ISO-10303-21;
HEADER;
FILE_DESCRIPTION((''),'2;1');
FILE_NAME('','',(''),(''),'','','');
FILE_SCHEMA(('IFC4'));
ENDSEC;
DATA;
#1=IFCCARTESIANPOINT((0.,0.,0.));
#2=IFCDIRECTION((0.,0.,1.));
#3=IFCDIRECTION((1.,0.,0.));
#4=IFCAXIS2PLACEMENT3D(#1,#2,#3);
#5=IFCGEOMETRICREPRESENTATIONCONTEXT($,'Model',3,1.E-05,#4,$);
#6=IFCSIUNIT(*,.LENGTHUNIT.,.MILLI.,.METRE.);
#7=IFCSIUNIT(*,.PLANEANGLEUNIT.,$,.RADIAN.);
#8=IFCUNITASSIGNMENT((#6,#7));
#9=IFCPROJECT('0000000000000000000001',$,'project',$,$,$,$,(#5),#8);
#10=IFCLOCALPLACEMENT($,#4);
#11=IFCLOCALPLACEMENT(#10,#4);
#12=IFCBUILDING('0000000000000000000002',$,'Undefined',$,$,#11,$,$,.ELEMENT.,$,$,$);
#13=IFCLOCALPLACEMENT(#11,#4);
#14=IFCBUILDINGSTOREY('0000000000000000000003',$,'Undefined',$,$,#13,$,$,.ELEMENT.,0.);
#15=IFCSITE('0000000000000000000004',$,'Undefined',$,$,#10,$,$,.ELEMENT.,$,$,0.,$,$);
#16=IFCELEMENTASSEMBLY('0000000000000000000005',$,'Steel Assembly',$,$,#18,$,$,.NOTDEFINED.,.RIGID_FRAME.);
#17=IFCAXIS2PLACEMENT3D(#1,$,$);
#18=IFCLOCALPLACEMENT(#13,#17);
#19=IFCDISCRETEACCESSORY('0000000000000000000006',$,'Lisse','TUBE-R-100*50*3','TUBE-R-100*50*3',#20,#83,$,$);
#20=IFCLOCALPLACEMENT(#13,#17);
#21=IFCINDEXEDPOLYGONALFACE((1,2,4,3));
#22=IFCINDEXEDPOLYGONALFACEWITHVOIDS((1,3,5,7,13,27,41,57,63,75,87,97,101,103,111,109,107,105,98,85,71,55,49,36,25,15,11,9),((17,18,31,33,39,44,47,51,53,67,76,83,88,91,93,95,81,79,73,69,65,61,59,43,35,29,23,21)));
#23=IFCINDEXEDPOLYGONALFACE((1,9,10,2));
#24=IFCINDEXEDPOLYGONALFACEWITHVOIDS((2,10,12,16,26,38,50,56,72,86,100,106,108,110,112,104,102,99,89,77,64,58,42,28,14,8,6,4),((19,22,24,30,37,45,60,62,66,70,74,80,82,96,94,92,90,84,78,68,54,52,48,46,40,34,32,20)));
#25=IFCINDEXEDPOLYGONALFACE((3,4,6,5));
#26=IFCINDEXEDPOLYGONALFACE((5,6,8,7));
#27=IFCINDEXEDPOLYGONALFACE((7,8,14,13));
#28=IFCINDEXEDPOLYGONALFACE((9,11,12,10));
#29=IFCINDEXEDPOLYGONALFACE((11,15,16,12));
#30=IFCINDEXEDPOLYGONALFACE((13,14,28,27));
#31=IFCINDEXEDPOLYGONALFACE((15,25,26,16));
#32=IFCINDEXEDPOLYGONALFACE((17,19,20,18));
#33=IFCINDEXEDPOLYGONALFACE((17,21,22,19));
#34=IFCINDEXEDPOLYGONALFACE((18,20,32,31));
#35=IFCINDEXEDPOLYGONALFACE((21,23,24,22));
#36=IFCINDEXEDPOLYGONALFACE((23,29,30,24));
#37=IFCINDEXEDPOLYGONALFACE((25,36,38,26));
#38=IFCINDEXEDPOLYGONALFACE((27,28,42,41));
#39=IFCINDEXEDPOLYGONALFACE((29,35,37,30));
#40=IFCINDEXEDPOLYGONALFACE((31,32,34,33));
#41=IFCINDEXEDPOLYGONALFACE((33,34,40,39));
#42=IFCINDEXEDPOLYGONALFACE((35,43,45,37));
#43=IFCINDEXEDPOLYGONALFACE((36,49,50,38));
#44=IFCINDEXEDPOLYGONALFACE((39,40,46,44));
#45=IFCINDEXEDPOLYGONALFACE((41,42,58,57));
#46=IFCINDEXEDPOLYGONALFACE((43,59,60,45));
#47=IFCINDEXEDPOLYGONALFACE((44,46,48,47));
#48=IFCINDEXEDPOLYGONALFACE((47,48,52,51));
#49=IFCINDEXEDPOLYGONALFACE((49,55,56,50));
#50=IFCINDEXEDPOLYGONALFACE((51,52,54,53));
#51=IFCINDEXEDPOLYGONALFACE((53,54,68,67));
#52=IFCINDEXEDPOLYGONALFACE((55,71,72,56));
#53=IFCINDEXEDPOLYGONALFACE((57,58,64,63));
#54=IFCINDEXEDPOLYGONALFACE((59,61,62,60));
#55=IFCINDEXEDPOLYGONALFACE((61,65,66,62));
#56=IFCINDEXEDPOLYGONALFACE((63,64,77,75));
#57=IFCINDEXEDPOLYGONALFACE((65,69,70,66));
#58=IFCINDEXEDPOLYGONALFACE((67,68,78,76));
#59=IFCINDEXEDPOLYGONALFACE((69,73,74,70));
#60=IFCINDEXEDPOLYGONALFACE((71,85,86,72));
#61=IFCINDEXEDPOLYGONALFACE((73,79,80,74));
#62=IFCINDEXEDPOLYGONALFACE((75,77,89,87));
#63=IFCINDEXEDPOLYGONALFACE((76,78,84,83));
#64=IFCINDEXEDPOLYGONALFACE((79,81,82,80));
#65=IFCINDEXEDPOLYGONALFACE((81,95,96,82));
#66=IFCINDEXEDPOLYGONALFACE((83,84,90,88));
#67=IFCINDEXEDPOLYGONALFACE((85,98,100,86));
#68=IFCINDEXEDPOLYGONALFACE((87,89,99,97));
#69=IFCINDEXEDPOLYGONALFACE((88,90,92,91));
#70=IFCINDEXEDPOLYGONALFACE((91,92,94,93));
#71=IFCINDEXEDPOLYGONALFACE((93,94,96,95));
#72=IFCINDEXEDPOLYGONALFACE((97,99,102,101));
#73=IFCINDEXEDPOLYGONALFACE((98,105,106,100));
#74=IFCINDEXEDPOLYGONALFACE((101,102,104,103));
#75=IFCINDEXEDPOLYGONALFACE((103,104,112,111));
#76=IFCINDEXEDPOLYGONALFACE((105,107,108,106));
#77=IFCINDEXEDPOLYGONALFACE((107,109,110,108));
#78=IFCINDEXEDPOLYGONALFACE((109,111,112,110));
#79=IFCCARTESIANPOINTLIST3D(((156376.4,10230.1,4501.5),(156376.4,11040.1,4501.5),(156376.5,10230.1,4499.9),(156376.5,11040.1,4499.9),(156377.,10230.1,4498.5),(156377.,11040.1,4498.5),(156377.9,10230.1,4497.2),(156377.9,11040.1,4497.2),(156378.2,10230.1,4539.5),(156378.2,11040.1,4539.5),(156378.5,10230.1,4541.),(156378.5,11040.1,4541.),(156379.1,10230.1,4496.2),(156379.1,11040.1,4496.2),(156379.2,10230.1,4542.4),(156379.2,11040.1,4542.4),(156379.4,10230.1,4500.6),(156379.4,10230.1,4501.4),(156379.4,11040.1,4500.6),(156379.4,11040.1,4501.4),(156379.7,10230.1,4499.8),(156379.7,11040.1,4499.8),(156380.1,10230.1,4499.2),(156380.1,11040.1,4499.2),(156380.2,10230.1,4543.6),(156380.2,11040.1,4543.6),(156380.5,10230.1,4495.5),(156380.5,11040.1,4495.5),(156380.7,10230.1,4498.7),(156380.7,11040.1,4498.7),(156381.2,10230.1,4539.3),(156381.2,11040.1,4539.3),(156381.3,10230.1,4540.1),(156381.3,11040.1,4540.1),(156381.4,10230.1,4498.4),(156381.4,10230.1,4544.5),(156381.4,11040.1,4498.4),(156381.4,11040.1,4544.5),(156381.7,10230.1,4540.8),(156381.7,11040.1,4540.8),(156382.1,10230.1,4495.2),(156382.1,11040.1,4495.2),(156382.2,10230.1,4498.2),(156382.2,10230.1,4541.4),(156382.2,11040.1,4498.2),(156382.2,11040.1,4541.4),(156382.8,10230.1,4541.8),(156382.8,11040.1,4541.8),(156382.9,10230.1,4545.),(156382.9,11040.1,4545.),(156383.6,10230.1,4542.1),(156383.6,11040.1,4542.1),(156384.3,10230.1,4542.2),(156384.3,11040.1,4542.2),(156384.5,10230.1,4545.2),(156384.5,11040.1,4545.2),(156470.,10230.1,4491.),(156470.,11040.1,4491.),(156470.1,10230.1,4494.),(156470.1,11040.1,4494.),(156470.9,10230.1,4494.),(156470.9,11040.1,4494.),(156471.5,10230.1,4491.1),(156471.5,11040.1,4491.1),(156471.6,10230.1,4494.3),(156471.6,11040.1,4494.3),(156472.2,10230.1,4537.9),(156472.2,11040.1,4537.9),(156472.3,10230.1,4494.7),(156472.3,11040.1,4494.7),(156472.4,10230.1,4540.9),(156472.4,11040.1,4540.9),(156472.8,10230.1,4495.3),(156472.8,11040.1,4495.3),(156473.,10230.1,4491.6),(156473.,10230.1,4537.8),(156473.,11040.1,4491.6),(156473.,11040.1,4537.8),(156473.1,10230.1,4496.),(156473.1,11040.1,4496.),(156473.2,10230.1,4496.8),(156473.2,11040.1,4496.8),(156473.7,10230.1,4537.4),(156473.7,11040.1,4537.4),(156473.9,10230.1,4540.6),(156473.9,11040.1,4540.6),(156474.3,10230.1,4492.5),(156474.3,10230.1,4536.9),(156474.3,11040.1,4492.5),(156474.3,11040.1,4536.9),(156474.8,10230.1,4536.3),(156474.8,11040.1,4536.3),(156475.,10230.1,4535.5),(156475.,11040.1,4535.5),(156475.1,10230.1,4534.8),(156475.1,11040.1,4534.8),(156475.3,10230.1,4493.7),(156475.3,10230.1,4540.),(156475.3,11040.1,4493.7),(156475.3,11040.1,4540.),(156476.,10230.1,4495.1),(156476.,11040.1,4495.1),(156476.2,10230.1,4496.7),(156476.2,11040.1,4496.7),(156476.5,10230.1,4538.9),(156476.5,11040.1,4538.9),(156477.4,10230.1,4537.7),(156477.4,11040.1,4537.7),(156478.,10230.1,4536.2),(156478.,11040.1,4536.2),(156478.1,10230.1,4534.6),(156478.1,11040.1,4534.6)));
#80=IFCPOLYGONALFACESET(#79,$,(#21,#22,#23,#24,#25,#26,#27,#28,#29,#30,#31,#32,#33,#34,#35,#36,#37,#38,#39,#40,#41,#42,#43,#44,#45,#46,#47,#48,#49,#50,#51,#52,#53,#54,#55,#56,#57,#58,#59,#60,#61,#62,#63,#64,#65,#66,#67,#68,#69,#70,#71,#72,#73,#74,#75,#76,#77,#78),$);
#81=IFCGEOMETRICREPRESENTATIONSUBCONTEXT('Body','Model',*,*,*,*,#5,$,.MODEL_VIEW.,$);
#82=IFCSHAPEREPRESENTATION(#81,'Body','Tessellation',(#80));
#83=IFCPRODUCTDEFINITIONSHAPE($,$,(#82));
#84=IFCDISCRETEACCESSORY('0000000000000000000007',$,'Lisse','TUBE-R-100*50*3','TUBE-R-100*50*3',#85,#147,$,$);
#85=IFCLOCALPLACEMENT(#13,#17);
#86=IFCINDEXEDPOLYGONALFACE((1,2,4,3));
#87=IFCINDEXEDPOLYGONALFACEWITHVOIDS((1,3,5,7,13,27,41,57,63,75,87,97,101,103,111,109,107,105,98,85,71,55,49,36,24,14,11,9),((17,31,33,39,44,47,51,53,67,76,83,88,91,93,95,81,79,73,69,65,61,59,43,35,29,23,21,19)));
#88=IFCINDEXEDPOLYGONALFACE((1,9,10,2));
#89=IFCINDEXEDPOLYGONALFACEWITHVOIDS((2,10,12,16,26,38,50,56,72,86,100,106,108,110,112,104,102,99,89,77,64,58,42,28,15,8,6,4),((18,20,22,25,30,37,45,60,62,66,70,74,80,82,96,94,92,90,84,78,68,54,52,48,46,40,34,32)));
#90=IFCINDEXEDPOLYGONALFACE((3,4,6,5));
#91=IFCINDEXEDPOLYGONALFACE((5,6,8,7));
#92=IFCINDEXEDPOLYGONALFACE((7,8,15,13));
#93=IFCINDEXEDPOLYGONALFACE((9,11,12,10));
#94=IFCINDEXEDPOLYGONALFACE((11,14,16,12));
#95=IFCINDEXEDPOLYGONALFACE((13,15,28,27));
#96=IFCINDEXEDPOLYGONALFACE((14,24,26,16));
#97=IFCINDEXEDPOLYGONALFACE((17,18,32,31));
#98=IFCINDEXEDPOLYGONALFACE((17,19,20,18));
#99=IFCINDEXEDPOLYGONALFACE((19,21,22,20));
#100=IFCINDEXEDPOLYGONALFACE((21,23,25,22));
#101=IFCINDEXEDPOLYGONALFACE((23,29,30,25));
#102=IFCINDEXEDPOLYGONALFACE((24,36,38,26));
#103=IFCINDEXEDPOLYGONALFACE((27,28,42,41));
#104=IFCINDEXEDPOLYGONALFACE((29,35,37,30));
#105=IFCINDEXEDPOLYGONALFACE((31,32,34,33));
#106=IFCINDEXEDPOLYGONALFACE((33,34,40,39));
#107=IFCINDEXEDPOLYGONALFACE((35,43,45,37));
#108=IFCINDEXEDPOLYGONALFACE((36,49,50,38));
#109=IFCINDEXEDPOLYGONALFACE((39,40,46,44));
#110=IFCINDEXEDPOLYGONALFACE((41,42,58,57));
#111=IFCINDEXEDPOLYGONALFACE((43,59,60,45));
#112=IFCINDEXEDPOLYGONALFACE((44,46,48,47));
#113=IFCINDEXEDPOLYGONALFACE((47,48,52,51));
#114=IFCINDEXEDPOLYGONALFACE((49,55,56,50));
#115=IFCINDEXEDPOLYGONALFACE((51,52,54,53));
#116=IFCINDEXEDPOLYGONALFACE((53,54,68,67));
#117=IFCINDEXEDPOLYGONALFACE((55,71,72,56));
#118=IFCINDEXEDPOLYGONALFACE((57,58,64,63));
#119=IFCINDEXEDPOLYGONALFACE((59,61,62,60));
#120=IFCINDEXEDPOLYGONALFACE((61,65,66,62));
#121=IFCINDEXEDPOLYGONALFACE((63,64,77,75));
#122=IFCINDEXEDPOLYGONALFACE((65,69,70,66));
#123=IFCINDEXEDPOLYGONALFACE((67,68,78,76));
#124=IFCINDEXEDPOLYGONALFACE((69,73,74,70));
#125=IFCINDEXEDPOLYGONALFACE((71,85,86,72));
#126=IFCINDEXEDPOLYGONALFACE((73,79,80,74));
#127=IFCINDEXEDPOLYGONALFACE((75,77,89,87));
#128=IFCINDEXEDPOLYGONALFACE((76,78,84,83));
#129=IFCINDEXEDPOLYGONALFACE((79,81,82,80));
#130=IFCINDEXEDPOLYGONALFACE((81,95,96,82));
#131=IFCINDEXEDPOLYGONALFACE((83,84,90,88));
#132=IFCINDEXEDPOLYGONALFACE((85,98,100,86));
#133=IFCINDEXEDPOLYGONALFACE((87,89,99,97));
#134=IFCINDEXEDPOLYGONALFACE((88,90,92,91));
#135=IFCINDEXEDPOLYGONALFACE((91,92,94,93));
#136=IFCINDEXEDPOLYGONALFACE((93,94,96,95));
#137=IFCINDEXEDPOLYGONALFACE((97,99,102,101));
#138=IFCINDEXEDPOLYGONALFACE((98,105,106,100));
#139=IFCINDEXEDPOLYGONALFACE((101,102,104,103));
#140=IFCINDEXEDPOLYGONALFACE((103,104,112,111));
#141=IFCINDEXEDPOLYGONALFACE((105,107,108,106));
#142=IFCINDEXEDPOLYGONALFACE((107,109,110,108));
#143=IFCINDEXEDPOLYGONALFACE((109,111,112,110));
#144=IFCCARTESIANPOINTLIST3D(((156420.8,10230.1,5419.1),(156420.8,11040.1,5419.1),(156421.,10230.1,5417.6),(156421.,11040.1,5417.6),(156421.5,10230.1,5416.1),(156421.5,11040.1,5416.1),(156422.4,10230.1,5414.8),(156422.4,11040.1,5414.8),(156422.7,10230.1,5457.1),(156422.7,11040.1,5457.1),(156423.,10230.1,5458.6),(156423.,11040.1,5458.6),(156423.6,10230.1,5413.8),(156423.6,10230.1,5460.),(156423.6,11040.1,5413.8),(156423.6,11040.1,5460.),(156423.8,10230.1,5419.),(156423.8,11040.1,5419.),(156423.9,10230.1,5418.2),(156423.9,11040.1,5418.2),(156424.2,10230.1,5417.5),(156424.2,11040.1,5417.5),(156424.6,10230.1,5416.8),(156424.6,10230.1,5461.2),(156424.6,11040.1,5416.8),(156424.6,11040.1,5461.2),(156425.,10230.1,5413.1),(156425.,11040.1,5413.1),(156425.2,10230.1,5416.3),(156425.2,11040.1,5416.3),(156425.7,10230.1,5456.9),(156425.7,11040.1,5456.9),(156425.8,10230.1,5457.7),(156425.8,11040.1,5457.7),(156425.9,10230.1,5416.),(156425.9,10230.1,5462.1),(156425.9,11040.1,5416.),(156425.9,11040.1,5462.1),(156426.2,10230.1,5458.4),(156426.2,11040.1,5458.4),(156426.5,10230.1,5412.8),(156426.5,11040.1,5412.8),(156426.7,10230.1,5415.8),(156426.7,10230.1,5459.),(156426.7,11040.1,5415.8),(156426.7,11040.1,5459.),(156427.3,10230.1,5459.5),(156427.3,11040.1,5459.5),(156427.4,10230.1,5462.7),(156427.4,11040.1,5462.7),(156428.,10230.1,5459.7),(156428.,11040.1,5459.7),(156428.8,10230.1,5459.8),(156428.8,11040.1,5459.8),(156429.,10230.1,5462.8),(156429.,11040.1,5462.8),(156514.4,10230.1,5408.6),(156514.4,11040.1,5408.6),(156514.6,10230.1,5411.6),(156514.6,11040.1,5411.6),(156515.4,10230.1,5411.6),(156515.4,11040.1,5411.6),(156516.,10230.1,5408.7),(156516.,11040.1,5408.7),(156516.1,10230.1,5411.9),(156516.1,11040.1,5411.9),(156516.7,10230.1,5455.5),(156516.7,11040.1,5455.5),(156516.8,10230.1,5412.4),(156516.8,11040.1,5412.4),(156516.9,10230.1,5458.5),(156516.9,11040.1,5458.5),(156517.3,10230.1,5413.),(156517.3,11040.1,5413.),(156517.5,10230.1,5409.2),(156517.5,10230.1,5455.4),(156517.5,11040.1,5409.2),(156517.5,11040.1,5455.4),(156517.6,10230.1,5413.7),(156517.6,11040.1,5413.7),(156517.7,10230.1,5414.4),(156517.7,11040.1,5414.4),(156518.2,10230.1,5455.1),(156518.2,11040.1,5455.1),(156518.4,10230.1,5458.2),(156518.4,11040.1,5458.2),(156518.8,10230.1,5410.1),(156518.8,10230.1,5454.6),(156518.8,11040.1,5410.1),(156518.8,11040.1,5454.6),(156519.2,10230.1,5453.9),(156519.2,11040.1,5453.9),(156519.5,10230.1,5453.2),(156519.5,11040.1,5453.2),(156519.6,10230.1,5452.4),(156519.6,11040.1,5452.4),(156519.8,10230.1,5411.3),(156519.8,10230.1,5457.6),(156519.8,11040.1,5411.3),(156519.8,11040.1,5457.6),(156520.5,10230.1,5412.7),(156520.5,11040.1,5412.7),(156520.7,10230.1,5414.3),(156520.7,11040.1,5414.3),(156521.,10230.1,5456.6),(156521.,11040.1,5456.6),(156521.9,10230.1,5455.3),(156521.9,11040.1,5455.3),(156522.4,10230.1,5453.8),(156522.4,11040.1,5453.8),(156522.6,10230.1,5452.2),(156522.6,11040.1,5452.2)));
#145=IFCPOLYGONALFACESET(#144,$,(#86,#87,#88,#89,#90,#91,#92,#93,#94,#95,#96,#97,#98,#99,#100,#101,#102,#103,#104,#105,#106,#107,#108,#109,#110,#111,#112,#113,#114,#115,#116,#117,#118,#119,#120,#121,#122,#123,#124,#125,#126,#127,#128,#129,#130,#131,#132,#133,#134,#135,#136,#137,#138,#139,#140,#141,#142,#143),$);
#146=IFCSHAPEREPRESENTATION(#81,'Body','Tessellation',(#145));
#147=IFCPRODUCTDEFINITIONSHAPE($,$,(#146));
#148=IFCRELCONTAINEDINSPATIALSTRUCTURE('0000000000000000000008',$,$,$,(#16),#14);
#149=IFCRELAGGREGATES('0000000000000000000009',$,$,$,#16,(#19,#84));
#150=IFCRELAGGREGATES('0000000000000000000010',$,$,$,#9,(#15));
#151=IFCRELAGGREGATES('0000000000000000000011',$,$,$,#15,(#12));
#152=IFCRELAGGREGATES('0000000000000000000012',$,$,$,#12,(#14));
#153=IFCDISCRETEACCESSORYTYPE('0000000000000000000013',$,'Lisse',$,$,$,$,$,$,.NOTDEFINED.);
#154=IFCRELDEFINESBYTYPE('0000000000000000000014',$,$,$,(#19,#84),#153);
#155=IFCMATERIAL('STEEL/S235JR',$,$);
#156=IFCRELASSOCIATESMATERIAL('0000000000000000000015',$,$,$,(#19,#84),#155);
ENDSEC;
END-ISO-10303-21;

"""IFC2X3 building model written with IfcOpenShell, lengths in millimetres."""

from ifc_helpers import new_model, si_unit, frame, origin_with_axes, origin_2d_with_axis, place, context, subcontext, project, spatial, hollow_rectangle, extrude, material, type_object, element, aggregate, save


model = new_model("IFC2X3")

# Units and contexts
model_context = context("Model", 3, precision=1e-05, world=origin_with_axes())
body_context = subcontext(model_context, "Body", "Model", "MODEL_VIEW")
ifc_project = project(units=[si_unit("LENGTHUNIT", "METRE", prefix="MILLI"), si_unit("PLANEANGLEUNIT", "RADIAN")], contexts=[model_context])

# Site, building, storey
site_placement = place(None, origin_with_axes())
site = spatial("IfcSite", under=ifc_project, at=site_placement, Name="Undefined", CompositionType="ELEMENT", RefElevation=0.0)
building_placement = place(site_placement, origin_with_axes())
building = spatial("IfcBuilding", under=site, at=building_placement, Name="Undefined", CompositionType="ELEMENT")
storey_placement = place(building_placement, origin_with_axes())
storey = spatial("IfcBuildingStorey", under=building, at=storey_placement, Name="Undefined", CompositionType="ELEMENT", Elevation=0.0)

# Shared definitions
ifc_material_1 = material(Name="STEEL/S235JR")

# Element assembly, discrete accessories
assembly_1_placement = place(storey_placement, origin_with_axes())
assembly_1 = element("IfcElementAssembly", 1, at=assembly_1_placement, inside=storey, Name="Steel Assembly", AssemblyPlace="NOTDEFINED", PredefinedType="RIGID_FRAME")
discrete_accessory_type_1 = type_object("IfcDiscreteAccessoryType", Name="Lisse")
discrete_accessory_1_placement = place(assembly_1_placement, frame((156427.2, 10230.1, 4518.1), z_axis=(-0.998827, 0.0, 0.048423), x_axis=(0.0, 1.0, 0.0)))
discrete_accessory_1 = element("IfcDiscreteAccessory", 2, at=discrete_accessory_1_placement, type_object=discrete_accessory_type_1, material=ifc_material_1, Name="Lisse", Description="TUBE-R-100*50*3", ObjectType="TUBE-R-100*50*3", context=body_context, shape_type="SweptSolid", body=[
    extrude(hollow_rectangle(XDim=50.0, YDim=100.0, WallThickness=3.0, InnerFilletRadius=3.0, OuterFilletRadius=6.0, at=origin_2d_with_axis()), frame((810.0, 0.0, 0.0), z_axis=(-1.0, 0.0, 0.0), x_axis=(0.0, -1.0, 0.0)), (0.0, 0.0, 1.0), 810.0),
])
discrete_accessory_2_placement = place(assembly_1_placement, frame((156471.7, 10230.1, 5435.7), z_axis=(-0.998827, 0.0, 0.048423), x_axis=(0.0, 1.0, 0.0)))
discrete_accessory_2 = element("IfcDiscreteAccessory", 3, at=discrete_accessory_2_placement, type_object=discrete_accessory_type_1, material=ifc_material_1, Name="Lisse", Description="TUBE-R-100*50*3", ObjectType="TUBE-R-100*50*3", context=body_context, shape_type="SweptSolid", body=[
    extrude(hollow_rectangle(XDim=50.0, YDim=100.0, WallThickness=3.0, InnerFilletRadius=3.0, OuterFilletRadius=6.0, at=origin_2d_with_axis()), frame((810.0, 0.0, 0.0), z_axis=(-1.0, 0.0, 0.0), x_axis=(0.0, -1.0, 0.0)), (0.0, 0.0, 1.0), 810.0),
])
aggregate(assembly_1, [discrete_accessory_1, discrete_accessory_2])

save(model, "model.ifc")
